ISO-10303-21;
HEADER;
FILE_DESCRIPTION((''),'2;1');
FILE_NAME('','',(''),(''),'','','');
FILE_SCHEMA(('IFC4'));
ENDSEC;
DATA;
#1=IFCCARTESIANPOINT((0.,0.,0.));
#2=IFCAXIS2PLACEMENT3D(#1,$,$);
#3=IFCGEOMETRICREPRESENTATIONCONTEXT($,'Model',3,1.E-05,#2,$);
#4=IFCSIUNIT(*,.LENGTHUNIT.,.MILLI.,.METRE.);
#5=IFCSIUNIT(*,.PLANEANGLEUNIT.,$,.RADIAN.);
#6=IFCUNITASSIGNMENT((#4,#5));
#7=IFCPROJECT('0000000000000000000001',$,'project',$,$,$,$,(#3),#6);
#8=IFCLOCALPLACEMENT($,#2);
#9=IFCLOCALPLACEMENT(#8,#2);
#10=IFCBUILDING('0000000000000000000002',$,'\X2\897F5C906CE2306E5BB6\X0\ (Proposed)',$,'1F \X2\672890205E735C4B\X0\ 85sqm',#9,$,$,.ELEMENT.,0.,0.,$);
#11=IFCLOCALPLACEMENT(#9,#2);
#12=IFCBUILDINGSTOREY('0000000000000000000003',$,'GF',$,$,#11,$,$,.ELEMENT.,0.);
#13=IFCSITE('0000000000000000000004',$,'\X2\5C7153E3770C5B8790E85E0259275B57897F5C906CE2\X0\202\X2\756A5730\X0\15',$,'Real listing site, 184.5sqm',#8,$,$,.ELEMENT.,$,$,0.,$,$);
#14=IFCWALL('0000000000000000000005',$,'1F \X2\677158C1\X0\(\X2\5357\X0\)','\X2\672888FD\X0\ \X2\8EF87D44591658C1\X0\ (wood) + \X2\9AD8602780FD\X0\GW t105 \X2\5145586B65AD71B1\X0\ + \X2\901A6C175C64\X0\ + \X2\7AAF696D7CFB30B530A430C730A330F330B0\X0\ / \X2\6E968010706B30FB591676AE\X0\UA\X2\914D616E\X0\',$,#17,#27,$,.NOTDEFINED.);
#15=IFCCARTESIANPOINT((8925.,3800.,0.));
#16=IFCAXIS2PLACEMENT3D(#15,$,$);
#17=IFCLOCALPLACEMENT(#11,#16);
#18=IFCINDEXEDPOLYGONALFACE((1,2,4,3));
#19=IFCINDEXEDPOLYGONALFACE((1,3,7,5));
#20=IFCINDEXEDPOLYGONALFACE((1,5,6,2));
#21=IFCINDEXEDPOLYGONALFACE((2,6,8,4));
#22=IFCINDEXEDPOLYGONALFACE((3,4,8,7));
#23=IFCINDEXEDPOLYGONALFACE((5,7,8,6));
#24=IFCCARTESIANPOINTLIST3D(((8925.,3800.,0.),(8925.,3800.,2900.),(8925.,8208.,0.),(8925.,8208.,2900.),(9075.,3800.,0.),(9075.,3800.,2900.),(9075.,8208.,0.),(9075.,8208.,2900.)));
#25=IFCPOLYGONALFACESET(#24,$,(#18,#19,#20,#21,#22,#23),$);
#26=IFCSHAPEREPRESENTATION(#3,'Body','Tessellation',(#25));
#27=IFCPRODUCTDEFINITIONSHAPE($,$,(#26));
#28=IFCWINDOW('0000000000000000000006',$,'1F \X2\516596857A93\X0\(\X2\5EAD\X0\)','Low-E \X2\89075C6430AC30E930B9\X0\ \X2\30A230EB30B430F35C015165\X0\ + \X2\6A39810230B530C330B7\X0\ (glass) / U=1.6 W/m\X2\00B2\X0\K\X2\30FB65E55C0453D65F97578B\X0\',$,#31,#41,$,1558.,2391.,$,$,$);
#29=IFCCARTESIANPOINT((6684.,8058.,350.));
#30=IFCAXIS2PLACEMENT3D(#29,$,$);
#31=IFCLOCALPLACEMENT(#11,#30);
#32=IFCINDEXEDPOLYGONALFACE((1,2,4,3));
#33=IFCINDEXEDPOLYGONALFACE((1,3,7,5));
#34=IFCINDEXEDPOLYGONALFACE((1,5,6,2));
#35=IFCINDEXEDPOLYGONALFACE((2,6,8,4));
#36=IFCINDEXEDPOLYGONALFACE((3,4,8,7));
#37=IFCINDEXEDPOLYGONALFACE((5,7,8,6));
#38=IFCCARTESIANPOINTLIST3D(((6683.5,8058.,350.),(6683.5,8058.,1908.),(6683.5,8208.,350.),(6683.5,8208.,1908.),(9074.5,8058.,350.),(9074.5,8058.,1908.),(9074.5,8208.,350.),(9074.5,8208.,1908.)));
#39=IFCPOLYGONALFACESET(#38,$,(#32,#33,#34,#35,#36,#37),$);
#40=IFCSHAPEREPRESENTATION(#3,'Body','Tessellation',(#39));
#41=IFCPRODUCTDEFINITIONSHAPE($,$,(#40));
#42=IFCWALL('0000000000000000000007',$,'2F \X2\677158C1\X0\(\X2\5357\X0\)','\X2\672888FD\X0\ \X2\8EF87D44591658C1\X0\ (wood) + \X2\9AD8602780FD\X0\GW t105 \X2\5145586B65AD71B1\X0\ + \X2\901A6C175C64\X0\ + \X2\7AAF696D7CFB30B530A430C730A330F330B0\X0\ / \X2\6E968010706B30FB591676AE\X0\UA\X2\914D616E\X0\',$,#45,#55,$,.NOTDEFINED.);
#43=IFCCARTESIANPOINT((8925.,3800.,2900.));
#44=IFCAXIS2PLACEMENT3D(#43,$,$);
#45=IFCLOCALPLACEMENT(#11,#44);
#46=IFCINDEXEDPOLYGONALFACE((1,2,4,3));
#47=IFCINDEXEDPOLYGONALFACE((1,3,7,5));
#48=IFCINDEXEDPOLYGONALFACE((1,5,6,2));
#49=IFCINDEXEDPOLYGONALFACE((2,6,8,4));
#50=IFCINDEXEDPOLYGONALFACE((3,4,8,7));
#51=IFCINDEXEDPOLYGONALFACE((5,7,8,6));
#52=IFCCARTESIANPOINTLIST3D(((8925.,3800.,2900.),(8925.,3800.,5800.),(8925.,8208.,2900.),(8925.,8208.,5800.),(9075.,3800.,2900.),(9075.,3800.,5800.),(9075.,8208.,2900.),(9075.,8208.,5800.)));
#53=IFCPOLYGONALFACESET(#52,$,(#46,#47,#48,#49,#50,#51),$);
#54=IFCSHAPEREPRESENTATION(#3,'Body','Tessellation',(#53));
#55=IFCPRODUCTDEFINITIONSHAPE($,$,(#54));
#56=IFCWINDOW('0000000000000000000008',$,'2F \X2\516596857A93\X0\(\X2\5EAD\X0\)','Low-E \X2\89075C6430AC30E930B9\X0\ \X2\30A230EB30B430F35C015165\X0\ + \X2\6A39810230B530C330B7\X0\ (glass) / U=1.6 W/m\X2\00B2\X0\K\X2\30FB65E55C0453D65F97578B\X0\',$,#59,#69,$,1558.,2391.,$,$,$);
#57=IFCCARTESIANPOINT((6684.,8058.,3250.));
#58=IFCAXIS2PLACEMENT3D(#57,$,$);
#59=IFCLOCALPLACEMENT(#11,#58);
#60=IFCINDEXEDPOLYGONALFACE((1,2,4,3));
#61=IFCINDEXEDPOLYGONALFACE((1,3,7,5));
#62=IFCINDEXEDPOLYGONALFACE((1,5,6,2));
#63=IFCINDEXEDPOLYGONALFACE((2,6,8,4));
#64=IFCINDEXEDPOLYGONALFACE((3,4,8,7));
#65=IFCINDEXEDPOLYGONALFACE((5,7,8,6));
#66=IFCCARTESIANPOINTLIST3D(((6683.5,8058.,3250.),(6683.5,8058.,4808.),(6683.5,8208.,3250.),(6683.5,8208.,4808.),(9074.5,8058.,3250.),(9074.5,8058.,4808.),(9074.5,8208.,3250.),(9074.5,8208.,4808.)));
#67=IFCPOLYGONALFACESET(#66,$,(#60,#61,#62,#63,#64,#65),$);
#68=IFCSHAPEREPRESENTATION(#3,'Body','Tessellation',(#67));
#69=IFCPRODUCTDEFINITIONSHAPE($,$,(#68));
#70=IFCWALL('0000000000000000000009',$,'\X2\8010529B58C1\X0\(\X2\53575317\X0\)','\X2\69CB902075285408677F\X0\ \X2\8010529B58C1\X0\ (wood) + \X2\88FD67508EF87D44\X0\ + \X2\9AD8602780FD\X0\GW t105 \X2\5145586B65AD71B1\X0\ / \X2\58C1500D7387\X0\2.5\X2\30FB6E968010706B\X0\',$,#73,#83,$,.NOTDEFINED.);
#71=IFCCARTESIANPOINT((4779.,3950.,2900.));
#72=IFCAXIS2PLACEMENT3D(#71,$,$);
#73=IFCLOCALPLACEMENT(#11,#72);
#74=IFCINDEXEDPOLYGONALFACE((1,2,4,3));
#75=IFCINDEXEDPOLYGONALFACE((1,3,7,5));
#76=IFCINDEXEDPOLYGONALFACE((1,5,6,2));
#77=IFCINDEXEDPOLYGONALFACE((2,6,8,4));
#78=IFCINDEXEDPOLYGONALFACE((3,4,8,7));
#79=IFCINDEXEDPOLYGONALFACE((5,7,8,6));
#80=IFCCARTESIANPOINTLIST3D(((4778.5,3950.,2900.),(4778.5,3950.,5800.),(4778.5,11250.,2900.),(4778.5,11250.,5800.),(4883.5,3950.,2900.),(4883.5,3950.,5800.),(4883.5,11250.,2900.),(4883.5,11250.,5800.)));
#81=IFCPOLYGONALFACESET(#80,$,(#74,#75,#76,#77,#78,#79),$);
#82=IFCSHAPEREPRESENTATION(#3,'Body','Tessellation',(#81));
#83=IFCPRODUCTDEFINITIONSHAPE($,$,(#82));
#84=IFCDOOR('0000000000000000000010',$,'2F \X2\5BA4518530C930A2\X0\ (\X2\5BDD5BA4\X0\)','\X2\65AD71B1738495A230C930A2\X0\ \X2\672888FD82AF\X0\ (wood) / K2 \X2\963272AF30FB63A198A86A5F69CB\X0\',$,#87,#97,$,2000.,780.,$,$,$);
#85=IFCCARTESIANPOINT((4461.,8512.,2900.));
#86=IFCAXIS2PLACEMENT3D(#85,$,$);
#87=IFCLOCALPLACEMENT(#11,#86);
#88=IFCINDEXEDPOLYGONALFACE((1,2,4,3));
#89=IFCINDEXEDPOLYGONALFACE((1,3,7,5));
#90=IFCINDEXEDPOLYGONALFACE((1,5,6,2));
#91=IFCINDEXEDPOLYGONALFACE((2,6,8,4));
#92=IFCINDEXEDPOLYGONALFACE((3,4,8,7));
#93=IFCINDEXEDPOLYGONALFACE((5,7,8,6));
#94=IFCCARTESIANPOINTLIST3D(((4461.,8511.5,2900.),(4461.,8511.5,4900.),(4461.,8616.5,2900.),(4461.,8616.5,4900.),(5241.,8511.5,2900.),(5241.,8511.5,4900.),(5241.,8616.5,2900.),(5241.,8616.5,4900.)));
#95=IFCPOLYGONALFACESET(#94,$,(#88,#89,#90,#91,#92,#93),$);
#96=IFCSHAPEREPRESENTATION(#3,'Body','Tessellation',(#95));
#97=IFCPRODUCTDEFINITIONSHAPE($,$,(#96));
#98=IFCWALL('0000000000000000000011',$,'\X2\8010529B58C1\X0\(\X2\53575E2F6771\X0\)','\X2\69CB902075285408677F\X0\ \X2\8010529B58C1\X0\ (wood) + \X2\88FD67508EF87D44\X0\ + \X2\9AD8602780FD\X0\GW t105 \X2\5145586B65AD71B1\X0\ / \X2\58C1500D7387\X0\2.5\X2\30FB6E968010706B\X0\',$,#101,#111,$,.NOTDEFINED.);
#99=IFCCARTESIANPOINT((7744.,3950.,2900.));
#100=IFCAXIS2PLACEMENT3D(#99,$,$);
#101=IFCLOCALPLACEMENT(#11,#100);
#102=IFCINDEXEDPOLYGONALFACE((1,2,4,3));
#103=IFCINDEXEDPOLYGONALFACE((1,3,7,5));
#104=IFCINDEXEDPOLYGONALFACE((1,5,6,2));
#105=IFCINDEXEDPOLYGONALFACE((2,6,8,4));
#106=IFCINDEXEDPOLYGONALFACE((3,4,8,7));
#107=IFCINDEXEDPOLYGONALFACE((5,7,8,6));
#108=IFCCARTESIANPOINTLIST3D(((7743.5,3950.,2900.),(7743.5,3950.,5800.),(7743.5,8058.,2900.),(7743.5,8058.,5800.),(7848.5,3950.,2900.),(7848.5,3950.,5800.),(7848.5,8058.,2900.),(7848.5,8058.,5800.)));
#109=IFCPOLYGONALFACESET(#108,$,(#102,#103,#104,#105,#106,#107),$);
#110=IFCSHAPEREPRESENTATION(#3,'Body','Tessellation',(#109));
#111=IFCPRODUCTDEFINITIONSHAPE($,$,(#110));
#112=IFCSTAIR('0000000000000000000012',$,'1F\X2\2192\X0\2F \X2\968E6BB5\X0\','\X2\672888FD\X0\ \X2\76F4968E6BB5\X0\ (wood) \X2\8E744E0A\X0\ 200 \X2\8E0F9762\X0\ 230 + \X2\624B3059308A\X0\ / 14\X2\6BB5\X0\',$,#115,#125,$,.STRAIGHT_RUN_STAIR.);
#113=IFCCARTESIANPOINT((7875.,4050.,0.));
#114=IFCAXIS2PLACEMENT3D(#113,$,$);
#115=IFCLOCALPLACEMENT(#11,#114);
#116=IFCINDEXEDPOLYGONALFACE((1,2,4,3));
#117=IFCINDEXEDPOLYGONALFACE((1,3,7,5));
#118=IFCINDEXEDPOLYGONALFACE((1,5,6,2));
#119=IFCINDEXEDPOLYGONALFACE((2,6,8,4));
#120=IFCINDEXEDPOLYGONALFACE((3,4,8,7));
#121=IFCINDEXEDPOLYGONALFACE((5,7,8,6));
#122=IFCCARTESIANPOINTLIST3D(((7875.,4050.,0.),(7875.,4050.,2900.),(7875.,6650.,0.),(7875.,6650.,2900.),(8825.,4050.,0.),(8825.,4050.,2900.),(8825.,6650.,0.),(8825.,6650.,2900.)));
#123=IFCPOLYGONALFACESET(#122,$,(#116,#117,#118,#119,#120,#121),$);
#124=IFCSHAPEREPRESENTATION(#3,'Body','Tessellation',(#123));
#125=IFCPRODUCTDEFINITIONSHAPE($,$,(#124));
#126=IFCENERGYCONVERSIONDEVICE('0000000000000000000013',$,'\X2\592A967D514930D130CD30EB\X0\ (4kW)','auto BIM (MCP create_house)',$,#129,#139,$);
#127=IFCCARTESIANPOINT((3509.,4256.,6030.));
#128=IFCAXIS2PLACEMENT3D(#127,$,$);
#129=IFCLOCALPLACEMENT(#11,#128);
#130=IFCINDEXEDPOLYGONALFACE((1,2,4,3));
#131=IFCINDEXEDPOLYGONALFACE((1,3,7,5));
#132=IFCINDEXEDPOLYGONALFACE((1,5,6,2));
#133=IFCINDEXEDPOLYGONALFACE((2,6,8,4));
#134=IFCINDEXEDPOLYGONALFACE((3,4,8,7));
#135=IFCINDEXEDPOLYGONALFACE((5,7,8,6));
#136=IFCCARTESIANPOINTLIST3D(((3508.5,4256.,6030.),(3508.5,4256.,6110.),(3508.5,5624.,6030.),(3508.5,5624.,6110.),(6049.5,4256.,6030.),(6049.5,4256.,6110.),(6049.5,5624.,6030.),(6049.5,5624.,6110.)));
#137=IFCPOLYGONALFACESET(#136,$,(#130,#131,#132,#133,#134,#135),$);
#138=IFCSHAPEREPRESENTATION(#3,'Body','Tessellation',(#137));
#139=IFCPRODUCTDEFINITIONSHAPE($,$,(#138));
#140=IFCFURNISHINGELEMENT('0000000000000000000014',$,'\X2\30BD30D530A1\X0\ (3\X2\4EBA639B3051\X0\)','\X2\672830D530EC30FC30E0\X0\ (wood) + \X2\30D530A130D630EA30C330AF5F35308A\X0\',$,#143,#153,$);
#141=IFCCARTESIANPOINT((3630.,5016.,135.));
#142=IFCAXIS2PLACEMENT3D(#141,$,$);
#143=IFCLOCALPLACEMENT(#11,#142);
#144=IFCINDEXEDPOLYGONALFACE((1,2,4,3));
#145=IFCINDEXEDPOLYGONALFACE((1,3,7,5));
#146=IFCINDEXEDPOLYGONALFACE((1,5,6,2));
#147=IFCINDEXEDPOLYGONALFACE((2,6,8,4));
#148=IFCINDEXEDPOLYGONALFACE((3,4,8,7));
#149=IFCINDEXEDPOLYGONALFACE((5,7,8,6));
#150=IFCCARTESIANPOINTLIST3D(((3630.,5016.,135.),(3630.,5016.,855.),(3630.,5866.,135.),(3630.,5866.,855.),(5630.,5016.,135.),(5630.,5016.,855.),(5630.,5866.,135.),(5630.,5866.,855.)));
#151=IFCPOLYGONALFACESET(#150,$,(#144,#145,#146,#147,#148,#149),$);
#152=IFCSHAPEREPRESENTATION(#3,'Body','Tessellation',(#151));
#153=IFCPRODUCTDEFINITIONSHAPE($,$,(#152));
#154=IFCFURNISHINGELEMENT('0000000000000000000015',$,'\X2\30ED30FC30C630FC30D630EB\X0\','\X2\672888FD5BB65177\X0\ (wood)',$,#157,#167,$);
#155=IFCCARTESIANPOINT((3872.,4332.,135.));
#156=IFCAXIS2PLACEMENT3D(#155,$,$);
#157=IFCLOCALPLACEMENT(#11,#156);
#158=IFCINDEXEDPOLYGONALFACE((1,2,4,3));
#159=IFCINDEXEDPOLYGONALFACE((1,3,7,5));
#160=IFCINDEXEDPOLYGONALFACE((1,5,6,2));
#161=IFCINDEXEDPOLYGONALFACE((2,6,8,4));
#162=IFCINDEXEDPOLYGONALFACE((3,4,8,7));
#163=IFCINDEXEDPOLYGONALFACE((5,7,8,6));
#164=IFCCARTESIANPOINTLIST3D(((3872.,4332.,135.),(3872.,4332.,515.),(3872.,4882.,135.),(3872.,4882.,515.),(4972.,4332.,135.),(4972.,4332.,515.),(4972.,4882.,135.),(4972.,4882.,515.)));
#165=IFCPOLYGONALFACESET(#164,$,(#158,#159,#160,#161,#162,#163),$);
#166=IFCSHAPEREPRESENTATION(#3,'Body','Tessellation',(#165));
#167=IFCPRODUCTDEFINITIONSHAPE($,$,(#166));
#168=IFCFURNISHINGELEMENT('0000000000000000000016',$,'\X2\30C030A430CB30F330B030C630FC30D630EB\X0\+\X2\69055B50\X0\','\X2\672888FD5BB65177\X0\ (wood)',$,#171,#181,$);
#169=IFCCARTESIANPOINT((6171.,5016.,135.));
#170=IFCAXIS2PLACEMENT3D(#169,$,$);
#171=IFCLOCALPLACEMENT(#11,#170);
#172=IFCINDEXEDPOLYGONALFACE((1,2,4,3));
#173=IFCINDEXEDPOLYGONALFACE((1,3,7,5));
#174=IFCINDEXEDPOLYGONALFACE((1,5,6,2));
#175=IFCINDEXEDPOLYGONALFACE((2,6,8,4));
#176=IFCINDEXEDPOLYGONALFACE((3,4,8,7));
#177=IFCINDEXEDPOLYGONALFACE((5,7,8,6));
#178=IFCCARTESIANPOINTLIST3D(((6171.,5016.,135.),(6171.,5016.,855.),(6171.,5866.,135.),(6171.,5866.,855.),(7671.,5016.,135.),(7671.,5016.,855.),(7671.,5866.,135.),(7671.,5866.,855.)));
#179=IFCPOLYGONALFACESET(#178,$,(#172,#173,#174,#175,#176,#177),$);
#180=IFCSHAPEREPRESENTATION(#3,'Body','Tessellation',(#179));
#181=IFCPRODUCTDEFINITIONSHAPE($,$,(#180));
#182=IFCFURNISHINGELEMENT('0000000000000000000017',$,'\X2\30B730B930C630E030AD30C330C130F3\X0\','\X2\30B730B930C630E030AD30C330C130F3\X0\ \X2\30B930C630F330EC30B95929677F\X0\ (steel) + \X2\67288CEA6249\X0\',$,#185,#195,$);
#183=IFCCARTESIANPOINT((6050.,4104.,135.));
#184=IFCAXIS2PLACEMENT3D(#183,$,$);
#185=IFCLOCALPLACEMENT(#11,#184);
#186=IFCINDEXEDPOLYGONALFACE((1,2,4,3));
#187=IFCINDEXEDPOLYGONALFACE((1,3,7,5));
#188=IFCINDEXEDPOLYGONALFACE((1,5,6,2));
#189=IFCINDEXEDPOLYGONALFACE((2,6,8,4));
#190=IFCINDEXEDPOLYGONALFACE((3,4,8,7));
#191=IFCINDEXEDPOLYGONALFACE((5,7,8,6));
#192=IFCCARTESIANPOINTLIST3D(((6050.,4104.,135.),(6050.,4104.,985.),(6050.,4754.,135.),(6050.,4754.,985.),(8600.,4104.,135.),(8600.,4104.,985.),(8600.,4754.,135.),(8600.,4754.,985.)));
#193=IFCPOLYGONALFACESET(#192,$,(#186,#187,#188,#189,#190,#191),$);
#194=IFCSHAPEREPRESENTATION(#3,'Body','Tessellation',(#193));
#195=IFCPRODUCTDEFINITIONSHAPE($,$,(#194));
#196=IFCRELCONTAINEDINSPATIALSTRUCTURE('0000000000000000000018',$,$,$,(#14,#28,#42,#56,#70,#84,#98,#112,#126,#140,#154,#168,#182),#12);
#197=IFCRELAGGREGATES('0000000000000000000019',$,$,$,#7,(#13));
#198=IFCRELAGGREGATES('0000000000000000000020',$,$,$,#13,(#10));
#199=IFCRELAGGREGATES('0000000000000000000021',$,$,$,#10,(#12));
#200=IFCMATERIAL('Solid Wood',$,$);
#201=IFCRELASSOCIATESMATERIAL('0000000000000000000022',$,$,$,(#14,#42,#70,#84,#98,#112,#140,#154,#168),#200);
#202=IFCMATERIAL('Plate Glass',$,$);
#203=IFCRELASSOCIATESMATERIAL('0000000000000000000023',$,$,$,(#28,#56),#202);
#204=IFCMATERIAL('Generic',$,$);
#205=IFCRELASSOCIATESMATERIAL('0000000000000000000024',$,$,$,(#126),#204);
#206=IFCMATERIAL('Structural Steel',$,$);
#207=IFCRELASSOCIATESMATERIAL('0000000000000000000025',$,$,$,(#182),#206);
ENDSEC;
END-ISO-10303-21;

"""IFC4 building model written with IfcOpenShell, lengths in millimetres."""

from ifc_helpers import new_model, si_unit, frame, frame_2d, origin, place, context, project, spatial, rectangle, extrude, material, element, fill, save


model = new_model("IFC4")

# Units and contexts
model_context = context("Model", 3, precision=1e-05, world=origin())
ifc_project = project(units=[si_unit("LENGTHUNIT", "METRE", prefix="MILLI"), si_unit("PLANEANGLEUNIT", "RADIAN")], contexts=[model_context])

# Site, building, storey
site_placement = place(None, origin())
site = spatial("IfcSite", under=ifc_project, at=site_placement, Name="山口県宇部市大字西岐波202番地15", ObjectType="Real listing site, 184.5sqm", CompositionType="ELEMENT", RefElevation=0.0)
building_placement = place(site_placement, origin())
building = spatial("IfcBuilding", under=site, at=building_placement, Name="西岐波の家 (Proposed)", ObjectType="1F 木造平屋 85sqm", CompositionType="ELEMENT", ElevationOfRefHeight=0.0, ElevationOfTerrain=0.0)
storey_placement = place(building_placement, origin())
storey = spatial("IfcBuildingStorey", under=building, at=storey_placement, Name="GF", CompositionType="ELEMENT", Elevation=0.0)

# Wall, opening, window
ifc_material_1 = material(Name="Solid Wood")
wall_1_placement = place(storey_placement, frame((8925.0, 3800.0, 0.0)))
wall_1 = element("IfcWall", 1, at=wall_1_placement, inside=storey, material=ifc_material_1, Name="1F 東壁(南)", Description="木製 軸組外壁 (wood) + 高性能GW t105 充填断熱 + 通気層 + 窯業系サイディング / 準耐火・外皮UA配慮", PredefinedType="NOTDEFINED", context=model_context, shape_type="SweptSolid", body=[
    extrude(rectangle(XDim=150.0, YDim=4408.0, at=frame_2d((75.0, 2204.0))), frame((8925.0, 3800.0, 0.0)), (0.0, 0.0, 1.0), 2900.0),
])
opening_1_placement = place(storey_placement, frame((6684.0, 8058.0, 350.0)))
opening_1 = element("IfcOpeningElement", 2, at=opening_1_placement, cuts=wall_1, PredefinedType="NOTDEFINED", context=model_context, shape_type="SweptSolid", body=[
    extrude(rectangle(XDim=2391.0, YDim=150.0, at=frame_2d((1195.0, 75.0))), frame((6684.0, 8058.0, 350.0)), (0.0, 0.0, 1.0), 1558.0),
])
ifc_material_2 = material(Name="Plate Glass")
window_1_placement = place(storey_placement, frame((6684.0, 8058.0, 350.0)))
window_1 = element("IfcWindow", 3, at=window_1_placement, inside=storey, material=ifc_material_2, Name="1F 入隅窓(庭)", Description="Low-E 複層ガラス アルゴン封入 + 樹脂サッシ (glass) / U=1.6 W/m²K・日射取得型", OverallHeight=1558.0, OverallWidth=2391.0, context=model_context, shape_type="SweptSolid", body=[
    extrude(rectangle(XDim=2391.0, YDim=150.0, at=frame_2d((1195.0, 75.0))), frame((6684.0, 8058.0, 350.0)), (0.0, 0.0, 1.0), 1558.0),
])
fill(opening_1, window_1)

# Wall, opening, window
wall_2_placement = place(storey_placement, frame((8925.0, 3800.0, 2900.0)))
wall_2 = element("IfcWall", 4, at=wall_2_placement, inside=storey, material=ifc_material_1, Name="2F 東壁(南)", Description="木製 軸組外壁 (wood) + 高性能GW t105 充填断熱 + 通気層 + 窯業系サイディング / 準耐火・外皮UA配慮", PredefinedType="NOTDEFINED", context=model_context, shape_type="SweptSolid", body=[
    extrude(rectangle(XDim=150.0, YDim=4408.0, at=frame_2d((75.0, 2204.0))), frame((8925.0, 3800.0, 2900.0)), (0.0, 0.0, 1.0), 2900.0),
])
opening_2_placement = place(storey_placement, frame((6684.0, 8058.0, 3250.0)))
opening_2 = element("IfcOpeningElement", 5, at=opening_2_placement, cuts=wall_2, PredefinedType="NOTDEFINED", context=model_context, shape_type="SweptSolid", body=[
    extrude(rectangle(XDim=2391.0, YDim=150.0, at=frame_2d((1195.0, 75.0))), frame((6684.0, 8058.0, 3250.0)), (0.0, 0.0, 1.0), 1558.0),
])
window_2_placement = place(storey_placement, frame((6684.0, 8058.0, 3250.0)))
window_2 = element("IfcWindow", 6, at=window_2_placement, inside=storey, material=ifc_material_2, Name="2F 入隅窓(庭)", Description="Low-E 複層ガラス アルゴン封入 + 樹脂サッシ (glass) / U=1.6 W/m²K・日射取得型", OverallHeight=1558.0, OverallWidth=2391.0, context=model_context, shape_type="SweptSolid", body=[
    extrude(rectangle(XDim=2391.0, YDim=150.0, at=frame_2d((1195.0, 75.0))), frame((6684.0, 8058.0, 3250.0)), (0.0, 0.0, 1.0), 1558.0),
])
fill(opening_2, window_2)

# Wall, opening, door
wall_3_placement = place(storey_placement, frame((4779.0, 3950.0, 2900.0)))
wall_3 = element("IfcWall", 7, at=wall_3_placement, inside=storey, material=ifc_material_1, Name="耐力壁(南北)", Description="構造用合板 耐力壁 (wood) + 製材軸組 + 高性能GW t105 充填断熱 / 壁倍率2.5・準耐火", PredefinedType="NOTDEFINED", context=model_context, shape_type="SweptSolid", body=[
    extrude(rectangle(XDim=105.0, YDim=7300.0, at=frame_2d((52.0, 3650.0))), frame((4779.0, 3950.0, 2900.0)), (0.0, 0.0, 1.0), 2900.0),
])
opening_3_placement = place(storey_placement, frame((4461.0, 8512.0, 2900.0)))
opening_3 = element("IfcOpeningElement", 8, at=opening_3_placement, cuts=wall_3, PredefinedType="NOTDEFINED", context=model_context, shape_type="SweptSolid", body=[
    extrude(rectangle(XDim=780.0, YDim=105.0, at=frame_2d((390.0, 52.0))), frame((4461.0, 8512.0, 2900.0)), (0.0, 0.0, 1.0), 2000.0),
])
door_1_placement = place(storey_placement, frame((4461.0, 8512.0, 2900.0)))
door_1 = element("IfcDoor", 9, at=door_1_placement, inside=storey, material=ifc_material_1, Name="2F 室内ドア (寝室)", Description="断熱玄関ドア 木製芯 (wood) / K2 防犯・採風機構", OverallHeight=2000.0, OverallWidth=780.0, context=model_context, shape_type="SweptSolid", body=[
    extrude(rectangle(XDim=780.0, YDim=105.0, at=frame_2d((390.0, 52.0))), frame((4461.0, 8512.0, 2900.0)), (0.0, 0.0, 1.0), 2000.0),
])
fill(opening_3, door_1)

# Wall
wall_4_placement = place(storey_placement, frame((7744.0, 3950.0, 2900.0)))
element("IfcWall", 10, at=wall_4_placement, inside=storey, material=ifc_material_1, Name="耐力壁(南帯東)", Description="構造用合板 耐力壁 (wood) + 製材軸組 + 高性能GW t105 充填断熱 / 壁倍率2.5・準耐火", PredefinedType="NOTDEFINED", context=model_context, shape_type="SweptSolid", body=[
    extrude(rectangle(XDim=105.0, YDim=4108.0, at=frame_2d((52.0, 2054.0))), frame((7744.0, 3950.0, 2900.0)), (0.0, 0.0, 1.0), 2900.0),
])

# Stair
stair_placement = place(storey_placement, frame((7875.0, 4050.0, 0.0)))
element("IfcStair", 11, at=stair_placement, inside=storey, material=ifc_material_1, Name="1F→2F 階段", Description="木製 直階段 (wood) 蹴上 200 踏面 230 + 手すり / 14段", PredefinedType="STRAIGHT_RUN_STAIR", context=model_context, shape_type="SweptSolid", body=[
    extrude(rectangle(XDim=950.0, YDim=2600.0, at=frame_2d((475.0, 1300.0))), frame((7875.0, 4050.0, 0.0)), (0.0, 0.0, 1.0), 2900.0),
])

# Energy conversion device
ifc_material_3 = material(Name="Generic")
energy_conversion_device_placement = place(storey_placement, frame((3509.0, 4256.0, 6030.0)))
element("IfcEnergyConversionDevice", 12, at=energy_conversion_device_placement, inside=storey, material=ifc_material_3, Name="太陽光パネル (4kW)", Description="auto BIM (MCP create_house)", context=model_context, shape_type="SweptSolid", body=[
    extrude(rectangle(XDim=2541.0, YDim=1368.0, at=frame_2d((1270.0, 684.0))), frame((3509.0, 4256.0, 6030.0)), (0.0, 0.0, 1.0), 80.0),
])

# Furnishing elements
furnishing_1_placement = place(storey_placement, frame((3630.0, 5016.0, 135.0)))
element("IfcFurnishingElement", 13, at=furnishing_1_placement, inside=storey, material=ifc_material_1, Name="ソファ (3人掛け)", Description="木フレーム (wood) + ファブリック張り", context=model_context, shape_type="SweptSolid", body=[
    extrude(rectangle(XDim=2000.0, YDim=850.0, at=frame_2d((1000.0, 425.0))), frame((3630.0, 5016.0, 135.0)), (0.0, 0.0, 1.0), 720.0),
])
furnishing_2_placement = place(storey_placement, frame((3872.0, 4332.0, 135.0)))
element("IfcFurnishingElement", 14, at=furnishing_2_placement, inside=storey, material=ifc_material_1, Name="ローテーブル", Description="木製家具 (wood)", context=model_context, shape_type="SweptSolid", body=[
    extrude(rectangle(XDim=1100.0, YDim=550.0, at=frame_2d((550.0, 275.0))), frame((3872.0, 4332.0, 135.0)), (0.0, 0.0, 1.0), 380.0),
])
furnishing_3_placement = place(storey_placement, frame((6171.0, 5016.0, 135.0)))
element("IfcFurnishingElement", 15, at=furnishing_3_placement, inside=storey, material=ifc_material_1, Name="ダイニングテーブル+椅子", Description="木製家具 (wood)", context=model_context, shape_type="SweptSolid", body=[
    extrude(rectangle(XDim=1500.0, YDim=850.0, at=frame_2d((750.0, 425.0))), frame((6171.0, 5016.0, 135.0)), (0.0, 0.0, 1.0), 720.0),
])
ifc_material_4 = material(Name="Structural Steel")
furnishing_4_placement = place(storey_placement, frame((6050.0, 4104.0, 135.0)))
element("IfcFurnishingElement", 16, at=furnishing_4_placement, inside=storey, material=ifc_material_4, Name="システムキッチン", Description="システムキッチン ステンレス天板 (steel) + 木質扉", context=model_context, shape_type="SweptSolid", body=[
    extrude(rectangle(XDim=2550.0, YDim=650.0, at=frame_2d((1275.0, 325.0))), frame((6050.0, 4104.0, 135.0)), (0.0, 0.0, 1.0), 850.0),
])

save(model, "model.ifc")
